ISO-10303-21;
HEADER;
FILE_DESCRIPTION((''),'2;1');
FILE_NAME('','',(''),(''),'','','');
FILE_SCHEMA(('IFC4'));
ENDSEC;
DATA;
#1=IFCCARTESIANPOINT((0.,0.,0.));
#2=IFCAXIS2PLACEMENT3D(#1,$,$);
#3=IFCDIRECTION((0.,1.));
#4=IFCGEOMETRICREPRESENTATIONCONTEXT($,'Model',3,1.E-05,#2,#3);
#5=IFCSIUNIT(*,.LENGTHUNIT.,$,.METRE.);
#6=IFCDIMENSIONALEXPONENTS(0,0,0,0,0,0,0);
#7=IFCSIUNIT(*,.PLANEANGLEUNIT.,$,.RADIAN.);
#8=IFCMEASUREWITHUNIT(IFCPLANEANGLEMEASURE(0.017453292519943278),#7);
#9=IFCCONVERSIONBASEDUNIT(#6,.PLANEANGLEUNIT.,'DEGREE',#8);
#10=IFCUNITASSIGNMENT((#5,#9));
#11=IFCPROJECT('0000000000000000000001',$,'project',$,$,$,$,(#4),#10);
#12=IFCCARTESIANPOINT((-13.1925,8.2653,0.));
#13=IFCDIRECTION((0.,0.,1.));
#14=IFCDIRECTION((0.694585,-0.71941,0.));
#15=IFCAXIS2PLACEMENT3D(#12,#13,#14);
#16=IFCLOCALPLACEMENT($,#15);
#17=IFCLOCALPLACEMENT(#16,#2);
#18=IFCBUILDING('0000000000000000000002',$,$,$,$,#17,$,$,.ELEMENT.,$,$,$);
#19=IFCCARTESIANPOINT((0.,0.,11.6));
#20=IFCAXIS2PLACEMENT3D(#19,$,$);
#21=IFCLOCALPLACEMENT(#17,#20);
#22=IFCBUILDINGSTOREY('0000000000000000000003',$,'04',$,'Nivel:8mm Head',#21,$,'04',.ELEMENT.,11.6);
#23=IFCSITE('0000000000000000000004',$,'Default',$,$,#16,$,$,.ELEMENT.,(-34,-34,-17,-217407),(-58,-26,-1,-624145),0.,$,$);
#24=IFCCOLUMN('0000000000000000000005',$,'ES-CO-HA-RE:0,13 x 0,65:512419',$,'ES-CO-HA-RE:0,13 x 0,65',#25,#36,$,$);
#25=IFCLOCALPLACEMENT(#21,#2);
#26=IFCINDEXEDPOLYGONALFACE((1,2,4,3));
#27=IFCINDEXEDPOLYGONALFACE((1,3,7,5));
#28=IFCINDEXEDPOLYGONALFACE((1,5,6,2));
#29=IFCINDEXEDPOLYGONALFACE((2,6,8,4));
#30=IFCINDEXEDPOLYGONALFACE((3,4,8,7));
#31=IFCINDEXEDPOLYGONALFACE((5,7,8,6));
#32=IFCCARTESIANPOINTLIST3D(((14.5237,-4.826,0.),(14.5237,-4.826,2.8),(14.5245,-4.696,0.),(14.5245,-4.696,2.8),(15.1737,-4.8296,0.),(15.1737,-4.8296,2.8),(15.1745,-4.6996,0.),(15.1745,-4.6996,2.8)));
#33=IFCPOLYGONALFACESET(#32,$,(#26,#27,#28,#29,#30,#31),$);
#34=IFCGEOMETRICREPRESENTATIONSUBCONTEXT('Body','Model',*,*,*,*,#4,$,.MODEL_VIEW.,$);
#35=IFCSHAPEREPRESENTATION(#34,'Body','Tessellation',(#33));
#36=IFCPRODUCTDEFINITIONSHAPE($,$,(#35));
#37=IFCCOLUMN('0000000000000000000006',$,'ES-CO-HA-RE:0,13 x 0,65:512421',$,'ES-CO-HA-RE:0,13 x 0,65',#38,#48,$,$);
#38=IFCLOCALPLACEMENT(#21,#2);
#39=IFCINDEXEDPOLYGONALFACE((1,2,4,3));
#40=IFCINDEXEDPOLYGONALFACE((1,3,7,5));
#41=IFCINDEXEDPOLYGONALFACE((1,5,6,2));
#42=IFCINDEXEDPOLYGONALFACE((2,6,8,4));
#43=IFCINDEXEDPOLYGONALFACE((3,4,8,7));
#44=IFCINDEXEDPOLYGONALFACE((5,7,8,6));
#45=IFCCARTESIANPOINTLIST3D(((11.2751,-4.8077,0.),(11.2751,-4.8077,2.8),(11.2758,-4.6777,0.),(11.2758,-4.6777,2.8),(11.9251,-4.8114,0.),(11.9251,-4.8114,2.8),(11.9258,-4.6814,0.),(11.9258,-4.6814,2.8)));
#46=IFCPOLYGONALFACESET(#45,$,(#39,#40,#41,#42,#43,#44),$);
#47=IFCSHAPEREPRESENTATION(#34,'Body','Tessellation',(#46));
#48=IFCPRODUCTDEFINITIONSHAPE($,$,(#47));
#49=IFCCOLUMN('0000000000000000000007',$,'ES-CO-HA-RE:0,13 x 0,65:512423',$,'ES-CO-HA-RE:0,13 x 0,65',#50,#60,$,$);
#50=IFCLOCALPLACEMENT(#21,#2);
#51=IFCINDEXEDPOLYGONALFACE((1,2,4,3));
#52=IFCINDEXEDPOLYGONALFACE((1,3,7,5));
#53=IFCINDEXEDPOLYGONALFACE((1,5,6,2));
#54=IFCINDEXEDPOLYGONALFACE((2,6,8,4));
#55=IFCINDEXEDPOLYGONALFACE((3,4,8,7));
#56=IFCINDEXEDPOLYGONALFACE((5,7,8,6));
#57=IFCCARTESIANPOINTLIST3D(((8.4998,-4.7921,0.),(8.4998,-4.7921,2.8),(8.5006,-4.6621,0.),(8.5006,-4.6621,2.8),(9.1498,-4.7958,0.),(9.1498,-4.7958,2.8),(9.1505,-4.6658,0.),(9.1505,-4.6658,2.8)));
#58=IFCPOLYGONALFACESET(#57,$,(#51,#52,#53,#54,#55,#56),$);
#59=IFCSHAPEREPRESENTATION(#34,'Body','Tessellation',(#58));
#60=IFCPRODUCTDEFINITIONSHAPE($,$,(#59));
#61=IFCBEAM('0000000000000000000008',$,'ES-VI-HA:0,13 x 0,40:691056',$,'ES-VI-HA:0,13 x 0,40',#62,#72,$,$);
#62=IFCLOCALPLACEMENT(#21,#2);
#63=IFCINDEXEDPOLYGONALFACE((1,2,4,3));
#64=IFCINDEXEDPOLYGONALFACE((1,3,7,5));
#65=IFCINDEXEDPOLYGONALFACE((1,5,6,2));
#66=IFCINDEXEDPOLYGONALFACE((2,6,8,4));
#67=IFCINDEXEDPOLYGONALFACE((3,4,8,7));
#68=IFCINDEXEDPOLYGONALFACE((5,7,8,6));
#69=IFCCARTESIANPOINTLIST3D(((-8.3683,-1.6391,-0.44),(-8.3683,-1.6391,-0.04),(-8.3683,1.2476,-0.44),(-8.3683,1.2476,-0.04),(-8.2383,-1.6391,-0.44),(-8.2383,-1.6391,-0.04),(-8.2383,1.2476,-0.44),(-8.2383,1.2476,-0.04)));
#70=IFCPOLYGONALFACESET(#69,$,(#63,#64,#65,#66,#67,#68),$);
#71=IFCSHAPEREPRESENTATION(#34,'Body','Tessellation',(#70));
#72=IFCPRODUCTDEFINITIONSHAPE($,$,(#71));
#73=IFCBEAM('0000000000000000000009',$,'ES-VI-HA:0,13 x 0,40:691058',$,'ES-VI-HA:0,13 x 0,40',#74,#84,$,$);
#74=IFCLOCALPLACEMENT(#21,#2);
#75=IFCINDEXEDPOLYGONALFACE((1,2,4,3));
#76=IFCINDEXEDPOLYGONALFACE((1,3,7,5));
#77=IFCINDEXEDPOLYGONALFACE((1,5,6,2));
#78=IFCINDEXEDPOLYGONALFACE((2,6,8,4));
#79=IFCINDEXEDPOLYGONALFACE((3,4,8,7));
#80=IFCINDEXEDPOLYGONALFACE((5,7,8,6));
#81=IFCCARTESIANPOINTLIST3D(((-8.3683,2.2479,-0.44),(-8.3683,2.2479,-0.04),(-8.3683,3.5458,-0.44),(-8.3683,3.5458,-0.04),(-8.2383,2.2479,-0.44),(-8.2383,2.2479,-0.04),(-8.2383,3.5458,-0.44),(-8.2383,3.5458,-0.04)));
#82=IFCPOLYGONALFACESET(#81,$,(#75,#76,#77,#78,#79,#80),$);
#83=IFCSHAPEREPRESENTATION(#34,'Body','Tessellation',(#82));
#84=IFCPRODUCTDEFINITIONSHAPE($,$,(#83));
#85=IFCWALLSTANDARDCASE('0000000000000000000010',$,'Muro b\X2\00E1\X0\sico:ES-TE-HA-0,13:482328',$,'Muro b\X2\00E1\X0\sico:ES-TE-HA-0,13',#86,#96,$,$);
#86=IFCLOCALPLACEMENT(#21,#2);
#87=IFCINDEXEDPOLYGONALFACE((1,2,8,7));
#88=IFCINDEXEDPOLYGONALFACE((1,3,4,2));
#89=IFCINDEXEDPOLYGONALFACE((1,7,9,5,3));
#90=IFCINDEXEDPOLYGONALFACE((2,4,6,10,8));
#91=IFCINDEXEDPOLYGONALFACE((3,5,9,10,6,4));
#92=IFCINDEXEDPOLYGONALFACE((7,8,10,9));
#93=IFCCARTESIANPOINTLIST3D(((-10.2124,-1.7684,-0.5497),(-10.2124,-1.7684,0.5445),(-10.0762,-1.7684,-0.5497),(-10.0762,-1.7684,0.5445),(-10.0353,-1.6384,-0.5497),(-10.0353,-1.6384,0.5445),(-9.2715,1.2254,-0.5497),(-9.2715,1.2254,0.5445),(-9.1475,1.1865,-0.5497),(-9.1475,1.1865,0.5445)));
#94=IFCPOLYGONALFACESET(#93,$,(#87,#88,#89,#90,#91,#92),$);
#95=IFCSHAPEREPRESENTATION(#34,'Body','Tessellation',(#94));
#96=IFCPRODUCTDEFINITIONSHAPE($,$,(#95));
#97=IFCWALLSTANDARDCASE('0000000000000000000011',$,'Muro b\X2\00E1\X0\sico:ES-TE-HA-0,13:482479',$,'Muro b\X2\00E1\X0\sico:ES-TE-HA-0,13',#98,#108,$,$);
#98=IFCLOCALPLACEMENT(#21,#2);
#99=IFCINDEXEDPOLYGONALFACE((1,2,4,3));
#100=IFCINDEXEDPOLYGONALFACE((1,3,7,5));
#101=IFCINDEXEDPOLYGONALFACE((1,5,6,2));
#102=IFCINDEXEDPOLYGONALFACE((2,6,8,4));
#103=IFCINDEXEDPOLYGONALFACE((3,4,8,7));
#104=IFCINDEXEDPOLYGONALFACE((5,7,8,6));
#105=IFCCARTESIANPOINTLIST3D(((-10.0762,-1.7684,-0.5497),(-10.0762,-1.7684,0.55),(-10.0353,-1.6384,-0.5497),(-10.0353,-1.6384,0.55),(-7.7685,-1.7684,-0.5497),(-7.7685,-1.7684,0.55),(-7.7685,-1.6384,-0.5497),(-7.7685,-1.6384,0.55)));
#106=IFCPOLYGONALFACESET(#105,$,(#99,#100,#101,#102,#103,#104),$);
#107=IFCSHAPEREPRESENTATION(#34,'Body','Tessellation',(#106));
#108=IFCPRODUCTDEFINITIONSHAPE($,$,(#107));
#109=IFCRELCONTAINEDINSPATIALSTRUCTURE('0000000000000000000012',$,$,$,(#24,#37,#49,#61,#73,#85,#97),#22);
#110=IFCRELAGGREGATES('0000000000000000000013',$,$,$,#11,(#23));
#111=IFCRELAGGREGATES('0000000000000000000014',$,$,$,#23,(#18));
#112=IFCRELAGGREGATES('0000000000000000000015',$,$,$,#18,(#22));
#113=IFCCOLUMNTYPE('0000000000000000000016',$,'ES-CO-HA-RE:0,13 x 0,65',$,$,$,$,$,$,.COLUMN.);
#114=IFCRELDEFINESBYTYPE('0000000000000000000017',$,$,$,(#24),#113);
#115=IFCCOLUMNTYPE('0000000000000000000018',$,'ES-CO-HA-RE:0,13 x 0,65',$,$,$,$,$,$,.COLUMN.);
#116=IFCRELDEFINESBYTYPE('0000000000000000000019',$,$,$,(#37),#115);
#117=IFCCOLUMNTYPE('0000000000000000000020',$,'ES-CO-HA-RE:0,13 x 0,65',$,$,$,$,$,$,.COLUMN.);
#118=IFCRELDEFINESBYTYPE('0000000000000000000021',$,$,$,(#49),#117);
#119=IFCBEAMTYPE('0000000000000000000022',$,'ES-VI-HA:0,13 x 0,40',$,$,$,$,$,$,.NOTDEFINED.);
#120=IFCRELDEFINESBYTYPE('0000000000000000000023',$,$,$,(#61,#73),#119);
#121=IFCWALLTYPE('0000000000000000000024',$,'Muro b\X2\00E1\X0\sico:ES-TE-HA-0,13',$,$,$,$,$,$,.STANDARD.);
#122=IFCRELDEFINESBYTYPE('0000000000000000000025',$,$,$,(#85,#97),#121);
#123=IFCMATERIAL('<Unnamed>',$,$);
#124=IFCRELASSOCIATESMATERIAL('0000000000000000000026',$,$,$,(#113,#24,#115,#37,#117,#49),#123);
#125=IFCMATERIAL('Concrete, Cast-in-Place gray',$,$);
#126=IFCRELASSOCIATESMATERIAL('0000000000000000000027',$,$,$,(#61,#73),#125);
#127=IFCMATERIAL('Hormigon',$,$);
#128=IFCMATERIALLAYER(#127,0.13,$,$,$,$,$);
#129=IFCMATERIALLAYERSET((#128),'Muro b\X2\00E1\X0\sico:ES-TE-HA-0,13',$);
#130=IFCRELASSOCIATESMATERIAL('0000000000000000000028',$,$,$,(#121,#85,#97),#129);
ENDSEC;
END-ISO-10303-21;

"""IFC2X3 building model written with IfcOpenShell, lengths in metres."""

from ifc_helpers import new_model, entity, si_unit, converted_unit, direction, frame, frame_2d, origin, origin_2d_with_axis, place, context, subcontext, project, spatial, polyline, rectangle, outline, extrude, source, transform, mapped, material, layer, layer_set, layer_usage, type_object, type_shapes, element, save


model = new_model("IFC2X3")

# Units and contexts
model_context = context("Model", 3, precision=1e-05, world=origin(), true_north=direction((0.0, 1.0)))
body_context = subcontext(model_context, "Body", "Model", "MODEL_VIEW")
ifc_project = project(units=[si_unit("LENGTHUNIT", "METRE"), converted_unit("PLANEANGLEUNIT", "DEGREE", entity("IfcPlaneAngleMeasure", 0.017453292519943278), si_unit("PLANEANGLEUNIT", "RADIAN"), dimensions=[0, 0, 0, 0, 0, 0, 0])], contexts=[model_context])

# Site, building, storey
site_placement = place(None, frame((-13.1925, 8.2653, 0.0), z_axis=(0.0, 0.0, 1.0), x_axis=(0.694585, -0.71941, 0.0)))
site = spatial("IfcSite", under=ifc_project, at=site_placement, Name="Default", CompositionType="ELEMENT", RefLatitude=(-34, -34, -17, -217407), RefLongitude=(-58, -26, -1, -624145), RefElevation=0.0)
building_placement = place(site_placement, origin())
building = spatial("IfcBuilding", under=site, at=building_placement, CompositionType="ELEMENT")
storey_placement = place(building_placement, frame((0.0, 0.0, 11.6)))
storey = spatial("IfcBuildingStorey", under=building, at=storey_placement, Name="04", ObjectType="Nivel:8mm Head", LongName="04", CompositionType="ELEMENT", Elevation=11.6)

# Columns
ifc_material_1 = material(Name="<Unnamed>")
column_type_1 = type_object("IfcColumnType", Name="ES-CO-HA-RE:0,13 x 0,65", PredefinedType="COLUMN", material=ifc_material_1)
shared_shape_1 = source(origin(), body_context, "Body", "SweptSolid", [
    extrude(rectangle(XDim=0.65, YDim=0.13, at=frame_2d((0.0, 0.0), x_axis=(1.0, 0.0))), frame((14.8491, -4.7628, 11.6), z_axis=(0.0, 0.0, 1.0), x_axis=(-0.999984, 0.005619, 0.0)), (0.0, 0.0, 1.0), 2.8),
])
type_shapes(column_type_1, [shared_shape_1])
column_1_placement = place(storey_placement, frame((0.0, 0.0, -11.6)))
element("IfcColumn", 1, at=column_1_placement, inside=storey, type_object=column_type_1, material=ifc_material_1, Name="ES-CO-HA-RE:0,13 x 0,65:512419", ObjectType="ES-CO-HA-RE:0,13 x 0,65", context=body_context, shape_type="MappedRepresentation", body=[
    mapped(shared_shape_1, transform((0.0, 0.0, 0.0), scale=1.0)),
])
column_type_2 = type_object("IfcColumnType", Name="ES-CO-HA-RE:0,13 x 0,65", PredefinedType="COLUMN", material=ifc_material_1)
shared_shape_2 = source(origin(), body_context, "Body", "SweptSolid", [
    extrude(rectangle(XDim=0.65, YDim=0.13, at=frame_2d((0.0, 0.0), x_axis=(1.0, 0.0))), frame((11.6005, -4.7445, 11.6), z_axis=(0.0, 0.0, 1.0), x_axis=(-0.999984, 0.005619, 0.0)), (0.0, 0.0, 1.0), 2.8),
])
type_shapes(column_type_2, [shared_shape_2])
column_2_placement = place(storey_placement, frame((0.0, 0.0, -11.6)))
element("IfcColumn", 2, at=column_2_placement, inside=storey, type_object=column_type_2, material=ifc_material_1, Name="ES-CO-HA-RE:0,13 x 0,65:512421", ObjectType="ES-CO-HA-RE:0,13 x 0,65", context=body_context, shape_type="MappedRepresentation", body=[
    mapped(shared_shape_2, transform((0.0, 0.0, 0.0), scale=1.0)),
])
column_type_3 = type_object("IfcColumnType", Name="ES-CO-HA-RE:0,13 x 0,65", PredefinedType="COLUMN", material=ifc_material_1)
shared_shape_3 = source(origin(), body_context, "Body", "SweptSolid", [
    extrude(rectangle(XDim=0.65, YDim=0.13, at=origin_2d_with_axis()), frame((8.8252, -4.7289, 11.6), z_axis=(0.0, 0.0, 1.0), x_axis=(-0.999984, 0.005619, 0.0)), (0.0, 0.0, 1.0), 2.8),
])
type_shapes(column_type_3, [shared_shape_3])
column_3_placement = place(storey_placement, frame((0.0, 0.0, -11.6)))
element("IfcColumn", 3, at=column_3_placement, inside=storey, type_object=column_type_3, material=ifc_material_1, Name="ES-CO-HA-RE:0,13 x 0,65:512423", ObjectType="ES-CO-HA-RE:0,13 x 0,65", context=body_context, shape_type="MappedRepresentation", body=[
    mapped(shared_shape_3, transform((0.0, 0.0, 0.0), scale=1.0)),
])

# Beams
ifc_material_2 = material(Name="Concrete, Cast-in-Place gray")
beam_type = type_object("IfcBeamType", Name="ES-VI-HA:0,13 x 0,40", PredefinedType="NOTDEFINED")
beam_1_placement = place(storey_placement, frame((-8.3033, -1.6391, -0.04), z_axis=(0.0, 0.0, 1.0), x_axis=(0.0, 1.0, 0.0)))
element("IfcBeam", 4, at=beam_1_placement, inside=storey, type_object=beam_type, material=ifc_material_2, Name="ES-VI-HA:0,13 x 0,40:691056", ObjectType="ES-VI-HA:0,13 x 0,40", context=body_context, shape_type="SweptSolid", body=[
    extrude(rectangle(XDim=0.4, YDim=0.13, at=frame_2d((0.0, 0.0), x_axis=(1.0, 0.0))), frame((0.0, 0.0, -0.2), z_axis=(1.0, 0.0, 0.0), x_axis=(0.0, 0.0, -1.0)), (0.0, 0.0, 1.0), 2.8867),
])
beam_2_placement = place(storey_placement, frame((-8.3033, 2.2479, -0.04), z_axis=(0.0, 0.0, 1.0), x_axis=(0.0, 1.0, 0.0)))
element("IfcBeam", 5, at=beam_2_placement, inside=storey, type_object=beam_type, material=ifc_material_2, Name="ES-VI-HA:0,13 x 0,40:691058", ObjectType="ES-VI-HA:0,13 x 0,40", context=body_context, shape_type="SweptSolid", body=[
    extrude(rectangle(XDim=0.4, YDim=0.13, at=frame_2d((0.0, 0.0), x_axis=(1.0, 0.0))), frame((0.0, 0.0, -0.2), z_axis=(1.0, 0.0, 0.0), x_axis=(0.0, 0.0, -1.0)), (0.0, 0.0, 1.0), 1.298),
])

# Shared definitions
ifc_material_3 = material(Name="Hormigon")

# Walls
ifc_layer_1 = layer(ifc_material_3, 0.13)
ifc_layer_set_1 = layer_set([ifc_layer_1], Name="Muro básico:ES-TE-HA-0,13")
ifc_layer_usage_1 = layer_usage(ifc_layer_set_1, "AXIS2", "NEGATIVE", 0.065)
wall_type = type_object("IfcWallType", Name="Muro básico:ES-TE-HA-0,13", PredefinedType="STANDARD", material=ifc_layer_set_1)
wall_1_placement = place(storey_placement, frame((-10.1504, -1.7879, -0.5497), z_axis=(0.0, 0.0, 1.0), x_axis=(0.299835, 0.953991, 0.0)))
element("IfcWallStandardCase", 6, at=wall_1_placement, inside=storey, type_object=wall_type, material=ifc_layer_usage_1, Name="Muro básico:ES-TE-HA-0,13:482328", ObjectType="Muro básico:ES-TE-HA-0,13", context=body_context, shape_type="SweptSolid", body=[
    extrude(outline(polyline([(3.1382, -0.065), (3.1382, 0.065), (0.0, 0.065), (0.0409, -0.065), (0.1771, -0.065), (3.1382, -0.065)])), origin(), (0.0, 0.0, 1.0), 1.0942),
])
ifc_layer_usage_2 = layer_usage(ifc_layer_set_1, "AXIS2", "POSITIVE", -0.065)
wall_2_placement = place(storey_placement, frame((-10.0762, -1.7034, -0.5497)))
element("IfcWallStandardCase", 7, at=wall_2_placement, inside=storey, type_object=wall_type, material=ifc_layer_usage_2, Name="Muro básico:ES-TE-HA-0,13:482479", ObjectType="Muro básico:ES-TE-HA-0,13", context=body_context, shape_type="SweptSolid", body=[
    extrude(outline(polyline([(2.3077, -0.065), (2.3077, 0.065), (0.0409, 0.065), (0.0, -0.065), (2.3077, -0.065)])), origin(), (0.0, 0.0, 1.0), 1.0997),
])

save(model, "model.ifc")
